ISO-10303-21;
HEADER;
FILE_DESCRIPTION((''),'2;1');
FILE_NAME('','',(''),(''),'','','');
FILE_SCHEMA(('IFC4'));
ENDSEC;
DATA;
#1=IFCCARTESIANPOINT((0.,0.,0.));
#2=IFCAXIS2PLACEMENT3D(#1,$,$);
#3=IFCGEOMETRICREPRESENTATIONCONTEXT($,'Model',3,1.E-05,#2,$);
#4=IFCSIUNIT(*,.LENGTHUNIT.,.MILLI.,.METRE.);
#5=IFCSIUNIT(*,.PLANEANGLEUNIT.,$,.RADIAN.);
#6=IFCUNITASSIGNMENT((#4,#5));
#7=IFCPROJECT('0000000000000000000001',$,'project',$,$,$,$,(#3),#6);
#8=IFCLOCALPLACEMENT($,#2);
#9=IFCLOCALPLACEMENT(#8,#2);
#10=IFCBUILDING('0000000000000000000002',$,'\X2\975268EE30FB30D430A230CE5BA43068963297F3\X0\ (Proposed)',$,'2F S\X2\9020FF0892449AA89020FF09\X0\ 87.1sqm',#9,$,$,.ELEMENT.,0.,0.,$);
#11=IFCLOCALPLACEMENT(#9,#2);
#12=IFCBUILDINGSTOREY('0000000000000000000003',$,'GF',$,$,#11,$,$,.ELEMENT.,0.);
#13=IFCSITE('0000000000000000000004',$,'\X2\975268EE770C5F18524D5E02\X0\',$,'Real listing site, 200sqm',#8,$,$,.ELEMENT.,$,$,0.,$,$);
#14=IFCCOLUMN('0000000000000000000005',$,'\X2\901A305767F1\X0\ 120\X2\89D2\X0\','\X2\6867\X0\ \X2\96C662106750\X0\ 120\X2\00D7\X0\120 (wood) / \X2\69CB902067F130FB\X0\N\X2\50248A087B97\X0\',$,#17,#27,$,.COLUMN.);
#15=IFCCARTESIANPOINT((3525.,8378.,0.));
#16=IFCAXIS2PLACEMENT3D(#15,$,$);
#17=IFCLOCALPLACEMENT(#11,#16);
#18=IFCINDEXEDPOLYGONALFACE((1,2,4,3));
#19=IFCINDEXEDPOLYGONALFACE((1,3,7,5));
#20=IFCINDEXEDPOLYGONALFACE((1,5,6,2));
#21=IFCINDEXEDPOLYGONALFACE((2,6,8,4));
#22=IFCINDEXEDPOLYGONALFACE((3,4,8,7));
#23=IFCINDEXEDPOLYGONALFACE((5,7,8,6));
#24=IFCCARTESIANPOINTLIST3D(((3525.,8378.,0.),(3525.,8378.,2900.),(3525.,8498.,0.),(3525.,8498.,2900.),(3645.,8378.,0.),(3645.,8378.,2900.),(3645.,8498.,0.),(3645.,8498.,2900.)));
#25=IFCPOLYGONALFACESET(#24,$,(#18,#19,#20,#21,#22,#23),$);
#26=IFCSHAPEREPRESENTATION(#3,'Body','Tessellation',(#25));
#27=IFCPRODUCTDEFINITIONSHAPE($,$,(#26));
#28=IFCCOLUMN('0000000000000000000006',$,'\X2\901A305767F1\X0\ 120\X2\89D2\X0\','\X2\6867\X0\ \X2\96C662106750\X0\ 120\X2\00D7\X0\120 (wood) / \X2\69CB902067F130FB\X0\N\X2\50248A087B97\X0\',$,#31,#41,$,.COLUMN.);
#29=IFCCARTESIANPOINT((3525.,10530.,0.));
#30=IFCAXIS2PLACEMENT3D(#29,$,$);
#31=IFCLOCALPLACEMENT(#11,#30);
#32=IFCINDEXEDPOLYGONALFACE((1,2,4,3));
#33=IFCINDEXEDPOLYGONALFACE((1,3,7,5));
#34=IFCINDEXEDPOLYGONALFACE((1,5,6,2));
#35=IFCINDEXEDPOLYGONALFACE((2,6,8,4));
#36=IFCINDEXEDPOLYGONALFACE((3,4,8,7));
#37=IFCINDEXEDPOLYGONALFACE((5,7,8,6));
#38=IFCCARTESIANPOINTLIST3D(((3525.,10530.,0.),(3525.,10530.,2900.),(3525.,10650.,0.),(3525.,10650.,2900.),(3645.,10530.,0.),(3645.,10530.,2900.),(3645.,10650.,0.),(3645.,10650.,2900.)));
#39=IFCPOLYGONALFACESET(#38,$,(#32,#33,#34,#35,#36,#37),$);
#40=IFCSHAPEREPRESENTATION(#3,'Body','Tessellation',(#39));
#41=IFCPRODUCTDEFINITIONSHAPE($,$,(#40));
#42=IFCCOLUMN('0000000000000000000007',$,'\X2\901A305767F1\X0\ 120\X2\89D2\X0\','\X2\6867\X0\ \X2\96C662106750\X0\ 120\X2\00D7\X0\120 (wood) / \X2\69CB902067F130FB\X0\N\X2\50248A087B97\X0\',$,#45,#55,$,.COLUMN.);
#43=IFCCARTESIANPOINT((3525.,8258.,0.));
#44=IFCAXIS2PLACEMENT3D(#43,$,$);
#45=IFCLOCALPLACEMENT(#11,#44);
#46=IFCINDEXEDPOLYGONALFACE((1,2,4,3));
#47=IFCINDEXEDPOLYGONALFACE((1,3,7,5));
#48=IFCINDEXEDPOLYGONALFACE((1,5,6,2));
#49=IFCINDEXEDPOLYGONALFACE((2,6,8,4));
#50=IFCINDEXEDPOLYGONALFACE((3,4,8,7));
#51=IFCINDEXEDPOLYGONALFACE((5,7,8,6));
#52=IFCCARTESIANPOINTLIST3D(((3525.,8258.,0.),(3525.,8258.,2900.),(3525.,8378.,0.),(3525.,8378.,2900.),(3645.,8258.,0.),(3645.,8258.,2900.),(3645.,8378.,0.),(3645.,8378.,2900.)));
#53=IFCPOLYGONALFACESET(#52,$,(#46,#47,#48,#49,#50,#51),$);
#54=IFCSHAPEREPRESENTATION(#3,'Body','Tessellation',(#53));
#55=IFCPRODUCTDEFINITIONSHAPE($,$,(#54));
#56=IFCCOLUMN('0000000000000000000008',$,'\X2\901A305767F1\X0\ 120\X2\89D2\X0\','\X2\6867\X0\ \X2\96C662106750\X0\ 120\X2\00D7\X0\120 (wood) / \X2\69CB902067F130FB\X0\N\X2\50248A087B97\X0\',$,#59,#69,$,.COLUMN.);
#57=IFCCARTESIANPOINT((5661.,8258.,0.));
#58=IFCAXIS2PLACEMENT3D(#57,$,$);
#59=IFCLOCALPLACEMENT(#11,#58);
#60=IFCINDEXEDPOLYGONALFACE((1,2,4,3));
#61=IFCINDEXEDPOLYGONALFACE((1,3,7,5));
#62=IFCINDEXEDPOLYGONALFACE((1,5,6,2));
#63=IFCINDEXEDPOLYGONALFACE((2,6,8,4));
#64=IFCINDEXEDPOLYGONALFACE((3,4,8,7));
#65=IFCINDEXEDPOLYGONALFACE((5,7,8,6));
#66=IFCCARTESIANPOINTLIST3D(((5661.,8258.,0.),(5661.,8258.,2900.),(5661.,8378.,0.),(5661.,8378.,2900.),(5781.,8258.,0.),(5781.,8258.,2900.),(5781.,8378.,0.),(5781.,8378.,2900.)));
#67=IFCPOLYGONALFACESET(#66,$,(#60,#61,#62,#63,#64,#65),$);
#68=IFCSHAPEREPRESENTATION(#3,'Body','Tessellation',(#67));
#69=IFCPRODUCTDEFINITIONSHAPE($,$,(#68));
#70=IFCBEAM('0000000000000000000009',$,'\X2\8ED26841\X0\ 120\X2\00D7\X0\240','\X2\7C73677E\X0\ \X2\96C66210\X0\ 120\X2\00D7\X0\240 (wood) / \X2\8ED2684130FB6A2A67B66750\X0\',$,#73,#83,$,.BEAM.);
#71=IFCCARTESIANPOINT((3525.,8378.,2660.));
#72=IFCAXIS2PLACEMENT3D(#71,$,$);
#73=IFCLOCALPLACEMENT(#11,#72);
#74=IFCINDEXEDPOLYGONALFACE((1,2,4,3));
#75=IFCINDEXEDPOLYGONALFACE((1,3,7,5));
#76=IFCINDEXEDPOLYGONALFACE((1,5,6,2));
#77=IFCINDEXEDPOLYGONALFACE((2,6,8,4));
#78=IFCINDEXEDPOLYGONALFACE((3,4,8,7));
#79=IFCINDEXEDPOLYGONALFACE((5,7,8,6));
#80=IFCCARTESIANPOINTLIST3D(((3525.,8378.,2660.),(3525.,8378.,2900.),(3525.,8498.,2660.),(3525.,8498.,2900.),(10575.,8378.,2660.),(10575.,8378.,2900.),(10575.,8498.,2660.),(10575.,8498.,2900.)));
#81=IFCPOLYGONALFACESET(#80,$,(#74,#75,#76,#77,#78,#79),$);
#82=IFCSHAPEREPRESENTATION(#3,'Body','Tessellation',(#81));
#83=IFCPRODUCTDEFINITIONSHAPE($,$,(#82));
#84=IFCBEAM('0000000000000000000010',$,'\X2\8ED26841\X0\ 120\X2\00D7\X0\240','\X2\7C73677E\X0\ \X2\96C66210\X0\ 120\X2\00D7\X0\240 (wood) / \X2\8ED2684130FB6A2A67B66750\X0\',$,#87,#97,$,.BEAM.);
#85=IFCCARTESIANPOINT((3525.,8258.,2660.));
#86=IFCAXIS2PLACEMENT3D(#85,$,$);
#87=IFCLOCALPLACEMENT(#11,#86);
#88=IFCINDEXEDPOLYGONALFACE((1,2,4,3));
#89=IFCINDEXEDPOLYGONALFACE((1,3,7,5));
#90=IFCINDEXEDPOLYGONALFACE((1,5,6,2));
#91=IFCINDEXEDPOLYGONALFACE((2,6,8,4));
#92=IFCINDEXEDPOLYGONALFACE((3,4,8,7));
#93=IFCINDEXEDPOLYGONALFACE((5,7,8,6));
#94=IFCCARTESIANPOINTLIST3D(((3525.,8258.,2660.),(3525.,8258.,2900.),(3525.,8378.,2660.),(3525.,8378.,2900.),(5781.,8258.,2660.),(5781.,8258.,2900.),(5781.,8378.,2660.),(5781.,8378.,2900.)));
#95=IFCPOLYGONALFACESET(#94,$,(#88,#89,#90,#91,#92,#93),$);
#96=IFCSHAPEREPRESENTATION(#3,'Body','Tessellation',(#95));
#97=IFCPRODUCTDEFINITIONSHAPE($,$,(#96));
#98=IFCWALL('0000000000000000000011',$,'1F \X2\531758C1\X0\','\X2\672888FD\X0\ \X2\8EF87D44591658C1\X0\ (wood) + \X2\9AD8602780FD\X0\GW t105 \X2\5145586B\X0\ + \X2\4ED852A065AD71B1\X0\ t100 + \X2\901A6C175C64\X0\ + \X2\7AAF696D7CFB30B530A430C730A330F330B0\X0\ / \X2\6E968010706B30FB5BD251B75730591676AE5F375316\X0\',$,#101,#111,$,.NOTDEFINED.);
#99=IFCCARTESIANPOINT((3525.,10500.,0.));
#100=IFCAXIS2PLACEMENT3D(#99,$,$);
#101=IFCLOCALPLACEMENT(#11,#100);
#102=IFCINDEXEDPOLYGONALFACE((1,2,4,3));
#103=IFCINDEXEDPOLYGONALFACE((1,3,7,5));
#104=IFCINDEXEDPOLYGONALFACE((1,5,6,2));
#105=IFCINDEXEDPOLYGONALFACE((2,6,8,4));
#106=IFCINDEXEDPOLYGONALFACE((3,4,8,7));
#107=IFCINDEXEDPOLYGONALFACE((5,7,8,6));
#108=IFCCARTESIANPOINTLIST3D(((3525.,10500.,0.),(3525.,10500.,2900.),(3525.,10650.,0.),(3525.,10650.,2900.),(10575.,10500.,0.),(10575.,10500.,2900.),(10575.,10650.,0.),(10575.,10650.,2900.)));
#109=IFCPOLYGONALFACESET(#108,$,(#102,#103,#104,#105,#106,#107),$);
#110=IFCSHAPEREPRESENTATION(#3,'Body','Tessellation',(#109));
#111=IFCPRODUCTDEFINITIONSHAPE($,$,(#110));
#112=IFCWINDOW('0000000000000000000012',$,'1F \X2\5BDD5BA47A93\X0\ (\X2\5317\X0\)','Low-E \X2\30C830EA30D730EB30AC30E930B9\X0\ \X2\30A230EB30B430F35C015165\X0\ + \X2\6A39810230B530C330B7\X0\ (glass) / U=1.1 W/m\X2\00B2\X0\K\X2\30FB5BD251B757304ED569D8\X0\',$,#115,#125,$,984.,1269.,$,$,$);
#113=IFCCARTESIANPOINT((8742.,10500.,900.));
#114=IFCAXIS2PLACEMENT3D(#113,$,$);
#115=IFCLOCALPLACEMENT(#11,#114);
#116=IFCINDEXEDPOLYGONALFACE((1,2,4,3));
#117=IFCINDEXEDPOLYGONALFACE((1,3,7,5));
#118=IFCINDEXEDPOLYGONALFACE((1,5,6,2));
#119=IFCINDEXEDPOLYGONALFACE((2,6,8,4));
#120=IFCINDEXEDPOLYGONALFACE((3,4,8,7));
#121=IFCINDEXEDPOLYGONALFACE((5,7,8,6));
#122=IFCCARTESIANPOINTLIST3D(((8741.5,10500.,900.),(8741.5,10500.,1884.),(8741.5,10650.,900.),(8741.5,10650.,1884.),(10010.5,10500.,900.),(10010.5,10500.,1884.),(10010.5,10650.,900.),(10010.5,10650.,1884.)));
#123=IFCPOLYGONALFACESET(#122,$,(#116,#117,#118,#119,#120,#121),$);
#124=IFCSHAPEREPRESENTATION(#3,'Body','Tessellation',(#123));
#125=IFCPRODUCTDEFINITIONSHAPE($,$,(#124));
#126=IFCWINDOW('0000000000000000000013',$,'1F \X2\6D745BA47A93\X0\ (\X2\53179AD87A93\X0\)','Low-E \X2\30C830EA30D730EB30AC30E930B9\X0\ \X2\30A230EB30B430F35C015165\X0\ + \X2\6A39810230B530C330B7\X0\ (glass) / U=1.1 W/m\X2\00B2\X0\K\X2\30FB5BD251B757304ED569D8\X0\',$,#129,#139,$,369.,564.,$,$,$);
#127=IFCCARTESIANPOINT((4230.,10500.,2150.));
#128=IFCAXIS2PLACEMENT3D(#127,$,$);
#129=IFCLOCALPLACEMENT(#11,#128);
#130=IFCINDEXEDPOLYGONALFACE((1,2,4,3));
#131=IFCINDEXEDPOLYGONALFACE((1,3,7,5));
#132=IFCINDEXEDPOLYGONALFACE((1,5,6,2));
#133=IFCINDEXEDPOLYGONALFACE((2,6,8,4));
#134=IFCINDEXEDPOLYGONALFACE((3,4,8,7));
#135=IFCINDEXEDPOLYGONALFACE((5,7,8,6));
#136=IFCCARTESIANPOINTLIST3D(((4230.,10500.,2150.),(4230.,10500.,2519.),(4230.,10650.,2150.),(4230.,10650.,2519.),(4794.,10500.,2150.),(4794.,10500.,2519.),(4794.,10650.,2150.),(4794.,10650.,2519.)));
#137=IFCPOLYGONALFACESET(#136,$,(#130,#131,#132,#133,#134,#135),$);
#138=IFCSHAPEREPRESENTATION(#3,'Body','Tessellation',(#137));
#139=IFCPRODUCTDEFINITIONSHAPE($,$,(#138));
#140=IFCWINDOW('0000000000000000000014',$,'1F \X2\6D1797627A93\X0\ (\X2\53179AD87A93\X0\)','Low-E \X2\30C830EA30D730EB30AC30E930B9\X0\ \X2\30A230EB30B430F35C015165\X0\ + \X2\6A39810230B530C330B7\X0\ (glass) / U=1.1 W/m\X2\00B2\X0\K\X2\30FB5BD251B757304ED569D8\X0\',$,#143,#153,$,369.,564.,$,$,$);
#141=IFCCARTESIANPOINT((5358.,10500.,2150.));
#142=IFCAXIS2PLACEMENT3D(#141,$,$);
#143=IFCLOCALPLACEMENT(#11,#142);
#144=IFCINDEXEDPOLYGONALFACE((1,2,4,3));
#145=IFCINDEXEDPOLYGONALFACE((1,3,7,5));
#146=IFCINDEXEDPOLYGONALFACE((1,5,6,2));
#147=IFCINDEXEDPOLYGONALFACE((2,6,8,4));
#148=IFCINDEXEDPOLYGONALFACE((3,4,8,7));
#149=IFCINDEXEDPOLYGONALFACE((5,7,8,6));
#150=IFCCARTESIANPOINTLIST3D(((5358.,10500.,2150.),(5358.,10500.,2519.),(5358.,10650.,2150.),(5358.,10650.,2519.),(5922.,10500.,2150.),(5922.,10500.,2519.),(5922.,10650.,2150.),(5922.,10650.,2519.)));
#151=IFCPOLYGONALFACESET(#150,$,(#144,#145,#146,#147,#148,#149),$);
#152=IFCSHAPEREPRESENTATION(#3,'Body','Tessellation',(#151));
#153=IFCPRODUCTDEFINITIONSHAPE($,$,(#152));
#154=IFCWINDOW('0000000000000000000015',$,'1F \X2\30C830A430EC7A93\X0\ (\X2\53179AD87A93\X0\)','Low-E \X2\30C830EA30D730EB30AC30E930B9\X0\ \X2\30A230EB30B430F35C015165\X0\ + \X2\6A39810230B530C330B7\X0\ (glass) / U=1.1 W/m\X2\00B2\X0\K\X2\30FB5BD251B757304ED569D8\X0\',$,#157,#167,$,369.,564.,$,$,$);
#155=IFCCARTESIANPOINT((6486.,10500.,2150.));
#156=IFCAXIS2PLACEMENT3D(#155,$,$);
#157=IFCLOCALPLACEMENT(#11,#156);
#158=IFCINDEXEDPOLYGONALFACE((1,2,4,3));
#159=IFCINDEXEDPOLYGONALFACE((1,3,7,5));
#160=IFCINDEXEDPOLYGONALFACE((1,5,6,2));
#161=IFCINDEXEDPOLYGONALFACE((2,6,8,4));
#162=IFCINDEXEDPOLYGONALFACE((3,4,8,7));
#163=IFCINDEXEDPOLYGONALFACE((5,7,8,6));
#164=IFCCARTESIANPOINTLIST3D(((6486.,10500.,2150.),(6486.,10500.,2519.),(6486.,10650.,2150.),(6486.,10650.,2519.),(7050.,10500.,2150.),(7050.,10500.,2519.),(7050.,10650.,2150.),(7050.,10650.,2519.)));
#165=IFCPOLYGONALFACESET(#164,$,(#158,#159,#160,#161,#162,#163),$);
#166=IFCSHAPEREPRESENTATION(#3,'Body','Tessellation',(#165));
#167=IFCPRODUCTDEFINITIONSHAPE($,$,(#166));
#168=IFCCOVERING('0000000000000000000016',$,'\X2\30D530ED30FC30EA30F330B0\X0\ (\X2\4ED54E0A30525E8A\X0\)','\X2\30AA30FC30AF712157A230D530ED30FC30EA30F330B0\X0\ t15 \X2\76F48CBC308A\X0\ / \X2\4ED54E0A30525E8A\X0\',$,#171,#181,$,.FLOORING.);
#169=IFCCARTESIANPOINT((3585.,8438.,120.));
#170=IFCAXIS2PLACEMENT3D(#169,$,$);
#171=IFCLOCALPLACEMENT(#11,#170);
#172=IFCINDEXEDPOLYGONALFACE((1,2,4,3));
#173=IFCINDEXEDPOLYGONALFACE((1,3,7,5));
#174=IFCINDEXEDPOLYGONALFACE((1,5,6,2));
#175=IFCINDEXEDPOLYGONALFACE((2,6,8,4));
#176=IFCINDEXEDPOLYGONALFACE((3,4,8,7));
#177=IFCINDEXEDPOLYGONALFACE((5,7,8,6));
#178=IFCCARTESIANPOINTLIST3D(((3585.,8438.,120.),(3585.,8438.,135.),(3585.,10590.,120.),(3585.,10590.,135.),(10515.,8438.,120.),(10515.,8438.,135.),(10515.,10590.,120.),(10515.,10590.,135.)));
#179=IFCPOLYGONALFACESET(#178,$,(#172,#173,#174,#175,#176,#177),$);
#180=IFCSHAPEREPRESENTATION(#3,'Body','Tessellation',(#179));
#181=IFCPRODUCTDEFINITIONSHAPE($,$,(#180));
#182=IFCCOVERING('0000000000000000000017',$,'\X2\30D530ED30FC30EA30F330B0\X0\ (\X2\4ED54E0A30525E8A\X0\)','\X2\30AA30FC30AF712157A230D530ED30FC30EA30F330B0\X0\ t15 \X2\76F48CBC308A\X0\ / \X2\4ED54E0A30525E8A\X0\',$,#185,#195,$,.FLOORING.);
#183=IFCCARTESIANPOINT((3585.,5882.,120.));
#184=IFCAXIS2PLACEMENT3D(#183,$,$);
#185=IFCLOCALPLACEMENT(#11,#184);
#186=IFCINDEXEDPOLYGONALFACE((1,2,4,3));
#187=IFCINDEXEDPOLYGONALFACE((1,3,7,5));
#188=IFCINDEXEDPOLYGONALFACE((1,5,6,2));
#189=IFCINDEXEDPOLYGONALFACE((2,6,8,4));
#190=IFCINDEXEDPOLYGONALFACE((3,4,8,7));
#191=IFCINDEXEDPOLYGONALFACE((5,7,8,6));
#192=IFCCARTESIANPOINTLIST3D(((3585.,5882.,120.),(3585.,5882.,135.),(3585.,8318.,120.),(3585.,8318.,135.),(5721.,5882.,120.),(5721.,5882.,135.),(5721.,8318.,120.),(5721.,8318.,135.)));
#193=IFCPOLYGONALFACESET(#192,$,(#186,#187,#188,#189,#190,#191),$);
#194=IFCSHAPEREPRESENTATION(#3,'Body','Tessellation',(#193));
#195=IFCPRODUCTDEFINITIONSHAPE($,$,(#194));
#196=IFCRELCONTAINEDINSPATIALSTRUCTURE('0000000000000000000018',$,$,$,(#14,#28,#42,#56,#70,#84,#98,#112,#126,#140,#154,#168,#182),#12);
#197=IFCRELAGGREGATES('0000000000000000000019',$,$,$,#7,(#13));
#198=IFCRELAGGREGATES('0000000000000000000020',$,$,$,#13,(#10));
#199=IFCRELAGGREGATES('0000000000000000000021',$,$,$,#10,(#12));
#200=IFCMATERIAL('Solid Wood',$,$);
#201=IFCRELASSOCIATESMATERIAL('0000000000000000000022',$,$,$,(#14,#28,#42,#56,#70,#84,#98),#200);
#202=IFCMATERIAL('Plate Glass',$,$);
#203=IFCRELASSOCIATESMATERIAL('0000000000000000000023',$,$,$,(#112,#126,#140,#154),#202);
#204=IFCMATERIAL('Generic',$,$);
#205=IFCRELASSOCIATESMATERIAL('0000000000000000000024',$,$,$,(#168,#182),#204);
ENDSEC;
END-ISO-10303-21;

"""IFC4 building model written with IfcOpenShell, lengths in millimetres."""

from ifc_helpers import new_model, si_unit, frame, frame_2d, origin, place, context, project, spatial, rectangle, extrude, material, element, fill, save


model = new_model("IFC4")

# Units and contexts
model_context = context("Model", 3, precision=1e-05, world=origin())
ifc_project = project(units=[si_unit("LENGTHUNIT", "METRE", prefix="MILLI"), si_unit("PLANEANGLEUNIT", "RADIAN")], contexts=[model_context])

# Site, building, storey
site_placement = place(None, origin())
site = spatial("IfcSite", under=ifc_project, at=site_placement, Name="青森県弘前市", ObjectType="Real listing site, 200sqm", CompositionType="ELEMENT", RefElevation=0.0)
building_placement = place(site_placement, origin())
building = spatial("IfcBuilding", under=site, at=building_placement, Name="青森・ピアノ室と防音 (Proposed)", ObjectType="2F S造（鉄骨造） 87.1sqm", CompositionType="ELEMENT", ElevationOfRefHeight=0.0, ElevationOfTerrain=0.0)
storey_placement = place(building_placement, origin())
storey = spatial("IfcBuildingStorey", under=building, at=storey_placement, Name="GF", CompositionType="ELEMENT", Elevation=0.0)

# Columns
ifc_material_1 = material(Name="Solid Wood")
column_1_placement = place(storey_placement, frame((3525.0, 8378.0, 0.0)))
element("IfcColumn", 1, at=column_1_placement, inside=storey, material=ifc_material_1, Name="通し柱 120角", Description="桧 集成材 120×120 (wood) / 構造柱・N値計算", PredefinedType="COLUMN", context=model_context, shape_type="SweptSolid", body=[
    extrude(rectangle(XDim=120.0, YDim=120.0, at=frame_2d((60.0, 60.0))), frame((3525.0, 8378.0, 0.0)), (0.0, 0.0, 1.0), 2900.0),
])
column_2_placement = place(storey_placement, frame((3525.0, 10530.0, 0.0)))
element("IfcColumn", 2, at=column_2_placement, inside=storey, material=ifc_material_1, Name="通し柱 120角", Description="桧 集成材 120×120 (wood) / 構造柱・N値計算", PredefinedType="COLUMN", context=model_context, shape_type="SweptSolid", body=[
    extrude(rectangle(XDim=120.0, YDim=120.0, at=frame_2d((60.0, 60.0))), frame((3525.0, 10530.0, 0.0)), (0.0, 0.0, 1.0), 2900.0),
])
column_3_placement = place(storey_placement, frame((3525.0, 8258.0, 0.0)))
element("IfcColumn", 3, at=column_3_placement, inside=storey, material=ifc_material_1, Name="通し柱 120角", Description="桧 集成材 120×120 (wood) / 構造柱・N値計算", PredefinedType="COLUMN", context=model_context, shape_type="SweptSolid", body=[
    extrude(rectangle(XDim=120.0, YDim=120.0, at=frame_2d((60.0, 60.0))), frame((3525.0, 8258.0, 0.0)), (0.0, 0.0, 1.0), 2900.0),
])
column_4_placement = place(storey_placement, frame((5661.0, 8258.0, 0.0)))
element("IfcColumn", 4, at=column_4_placement, inside=storey, material=ifc_material_1, Name="通し柱 120角", Description="桧 集成材 120×120 (wood) / 構造柱・N値計算", PredefinedType="COLUMN", context=model_context, shape_type="SweptSolid", body=[
    extrude(rectangle(XDim=120.0, YDim=120.0, at=frame_2d((60.0, 60.0))), frame((5661.0, 8258.0, 0.0)), (0.0, 0.0, 1.0), 2900.0),
])

# Beams
beam_1_placement = place(storey_placement, frame((3525.0, 8378.0, 2660.0)))
element("IfcBeam", 5, at=beam_1_placement, inside=storey, material=ifc_material_1, Name="軒桁 120×240", Description="米松 集成 120×240 (wood) / 軒桁・横架材", PredefinedType="BEAM", context=model_context, shape_type="SweptSolid", body=[
    extrude(rectangle(XDim=7050.0, YDim=120.0, at=frame_2d((3525.0, 60.0))), frame((3525.0, 8378.0, 2660.0)), (0.0, 0.0, 1.0), 240.0),
])
beam_2_placement = place(storey_placement, frame((3525.0, 8258.0, 2660.0)))
element("IfcBeam", 6, at=beam_2_placement, inside=storey, material=ifc_material_1, Name="軒桁 120×240", Description="米松 集成 120×240 (wood) / 軒桁・横架材", PredefinedType="BEAM", context=model_context, shape_type="SweptSolid", body=[
    extrude(rectangle(XDim=2256.0, YDim=120.0, at=frame_2d((1128.0, 60.0))), frame((3525.0, 8258.0, 2660.0)), (0.0, 0.0, 1.0), 240.0),
])

# Wall, openings, windows
wall_1_placement = place(storey_placement, frame((3525.0, 10500.0, 0.0)))
wall_1 = element("IfcWall", 7, at=wall_1_placement, inside=storey, material=ifc_material_1, Name="1F 北壁", Description="木製 軸組外壁 (wood) + 高性能GW t105 充填 + 付加断熱 t100 + 通気層 + 窯業系サイディング / 準耐火・寒冷地外皮強化", PredefinedType="NOTDEFINED", context=model_context, shape_type="SweptSolid", body=[
    extrude(rectangle(XDim=7050.0, YDim=150.0, at=frame_2d((3525.0, 75.0))), frame((3525.0, 10500.0, 0.0)), (0.0, 0.0, 1.0), 2900.0),
])
opening_1_placement = place(storey_placement, frame((8742.0, 10500.0, 900.0)))
opening_1 = element("IfcOpeningElement", 8, at=opening_1_placement, cuts=wall_1, PredefinedType="NOTDEFINED", context=model_context, shape_type="SweptSolid", body=[
    extrude(rectangle(XDim=1269.0, YDim=150.0, at=frame_2d((634.0, 75.0))), frame((8742.0, 10500.0, 900.0)), (0.0, 0.0, 1.0), 984.0),
])
opening_2_placement = place(storey_placement, frame((4230.0, 10500.0, 2150.0)))
opening_2 = element("IfcOpeningElement", 9, at=opening_2_placement, cuts=wall_1, PredefinedType="NOTDEFINED", context=model_context, shape_type="SweptSolid", body=[
    extrude(rectangle(XDim=564.0, YDim=150.0, at=frame_2d((282.0, 75.0))), frame((4230.0, 10500.0, 2150.0)), (0.0, 0.0, 1.0), 369.0),
])
opening_3_placement = place(storey_placement, frame((5358.0, 10500.0, 2150.0)))
opening_3 = element("IfcOpeningElement", 10, at=opening_3_placement, cuts=wall_1, PredefinedType="NOTDEFINED", context=model_context, shape_type="SweptSolid", body=[
    extrude(rectangle(XDim=564.0, YDim=150.0, at=frame_2d((282.0, 75.0))), frame((5358.0, 10500.0, 2150.0)), (0.0, 0.0, 1.0), 369.0),
])
opening_4_placement = place(storey_placement, frame((6486.0, 10500.0, 2150.0)))
opening_4 = element("IfcOpeningElement", 11, at=opening_4_placement, cuts=wall_1, PredefinedType="NOTDEFINED", context=model_context, shape_type="SweptSolid", body=[
    extrude(rectangle(XDim=564.0, YDim=150.0, at=frame_2d((282.0, 75.0))), frame((6486.0, 10500.0, 2150.0)), (0.0, 0.0, 1.0), 369.0),
])
ifc_material_2 = material(Name="Plate Glass")
window_1_placement = place(storey_placement, frame((8742.0, 10500.0, 900.0)))
window_1 = element("IfcWindow", 12, at=window_1_placement, inside=storey, material=ifc_material_2, Name="1F 寝室窓 (北)", Description="Low-E トリプルガラス アルゴン封入 + 樹脂サッシ (glass) / U=1.1 W/m²K・寒冷地仕様", OverallHeight=984.0, OverallWidth=1269.0, context=model_context, shape_type="SweptSolid", body=[
    extrude(rectangle(XDim=1269.0, YDim=150.0, at=frame_2d((634.0, 75.0))), frame((8742.0, 10500.0, 900.0)), (0.0, 0.0, 1.0), 984.0),
])
fill(opening_1, window_1)
window_2_placement = place(storey_placement, frame((4230.0, 10500.0, 2150.0)))
window_2 = element("IfcWindow", 13, at=window_2_placement, inside=storey, material=ifc_material_2, Name="1F 浴室窓 (北高窓)", Description="Low-E トリプルガラス アルゴン封入 + 樹脂サッシ (glass) / U=1.1 W/m²K・寒冷地仕様", OverallHeight=369.0, OverallWidth=564.0, context=model_context, shape_type="SweptSolid", body=[
    extrude(rectangle(XDim=564.0, YDim=150.0, at=frame_2d((282.0, 75.0))), frame((4230.0, 10500.0, 2150.0)), (0.0, 0.0, 1.0), 369.0),
])
fill(opening_2, window_2)
window_3_placement = place(storey_placement, frame((5358.0, 10500.0, 2150.0)))
window_3 = element("IfcWindow", 14, at=window_3_placement, inside=storey, material=ifc_material_2, Name="1F 洗面窓 (北高窓)", Description="Low-E トリプルガラス アルゴン封入 + 樹脂サッシ (glass) / U=1.1 W/m²K・寒冷地仕様", OverallHeight=369.0, OverallWidth=564.0, context=model_context, shape_type="SweptSolid", body=[
    extrude(rectangle(XDim=564.0, YDim=150.0, at=frame_2d((282.0, 75.0))), frame((5358.0, 10500.0, 2150.0)), (0.0, 0.0, 1.0), 369.0),
])
fill(opening_3, window_3)
window_4_placement = place(storey_placement, frame((6486.0, 10500.0, 2150.0)))
window_4 = element("IfcWindow", 15, at=window_4_placement, inside=storey, material=ifc_material_2, Name="1F トイレ窓 (北高窓)", Description="Low-E トリプルガラス アルゴン封入 + 樹脂サッシ (glass) / U=1.1 W/m²K・寒冷地仕様", OverallHeight=369.0, OverallWidth=564.0, context=model_context, shape_type="SweptSolid", body=[
    extrude(rectangle(XDim=564.0, YDim=150.0, at=frame_2d((282.0, 75.0))), frame((6486.0, 10500.0, 2150.0)), (0.0, 0.0, 1.0), 369.0),
])
fill(opening_4, window_4)

# Coverings
ifc_material_3 = material(Name="Generic")
covering_1_placement = place(storey_placement, frame((3585.0, 8438.0, 120.0)))
element("IfcCovering", 16, at=covering_1_placement, inside=storey, material=ifc_material_3, Name="フローリング (仕上げ床)", Description="オーク無垢フローリング t15 直貼り / 仕上げ床", PredefinedType="FLOORING", context=model_context, shape_type="SweptSolid", body=[
    extrude(rectangle(XDim=6930.0, YDim=2152.0, at=frame_2d((3465.0, 1076.0))), frame((3585.0, 8438.0, 120.0)), (0.0, 0.0, 1.0), 15.0),
])
covering_2_placement = place(storey_placement, frame((3585.0, 5882.0, 120.0)))
element("IfcCovering", 17, at=covering_2_placement, inside=storey, material=ifc_material_3, Name="フローリング (仕上げ床)", Description="オーク無垢フローリング t15 直貼り / 仕上げ床", PredefinedType="FLOORING", context=model_context, shape_type="SweptSolid", body=[
    extrude(rectangle(XDim=2136.0, YDim=2436.0, at=frame_2d((1068.0, 1218.0))), frame((3585.0, 5882.0, 120.0)), (0.0, 0.0, 1.0), 15.0),
])

save(model, "model.ifc")
